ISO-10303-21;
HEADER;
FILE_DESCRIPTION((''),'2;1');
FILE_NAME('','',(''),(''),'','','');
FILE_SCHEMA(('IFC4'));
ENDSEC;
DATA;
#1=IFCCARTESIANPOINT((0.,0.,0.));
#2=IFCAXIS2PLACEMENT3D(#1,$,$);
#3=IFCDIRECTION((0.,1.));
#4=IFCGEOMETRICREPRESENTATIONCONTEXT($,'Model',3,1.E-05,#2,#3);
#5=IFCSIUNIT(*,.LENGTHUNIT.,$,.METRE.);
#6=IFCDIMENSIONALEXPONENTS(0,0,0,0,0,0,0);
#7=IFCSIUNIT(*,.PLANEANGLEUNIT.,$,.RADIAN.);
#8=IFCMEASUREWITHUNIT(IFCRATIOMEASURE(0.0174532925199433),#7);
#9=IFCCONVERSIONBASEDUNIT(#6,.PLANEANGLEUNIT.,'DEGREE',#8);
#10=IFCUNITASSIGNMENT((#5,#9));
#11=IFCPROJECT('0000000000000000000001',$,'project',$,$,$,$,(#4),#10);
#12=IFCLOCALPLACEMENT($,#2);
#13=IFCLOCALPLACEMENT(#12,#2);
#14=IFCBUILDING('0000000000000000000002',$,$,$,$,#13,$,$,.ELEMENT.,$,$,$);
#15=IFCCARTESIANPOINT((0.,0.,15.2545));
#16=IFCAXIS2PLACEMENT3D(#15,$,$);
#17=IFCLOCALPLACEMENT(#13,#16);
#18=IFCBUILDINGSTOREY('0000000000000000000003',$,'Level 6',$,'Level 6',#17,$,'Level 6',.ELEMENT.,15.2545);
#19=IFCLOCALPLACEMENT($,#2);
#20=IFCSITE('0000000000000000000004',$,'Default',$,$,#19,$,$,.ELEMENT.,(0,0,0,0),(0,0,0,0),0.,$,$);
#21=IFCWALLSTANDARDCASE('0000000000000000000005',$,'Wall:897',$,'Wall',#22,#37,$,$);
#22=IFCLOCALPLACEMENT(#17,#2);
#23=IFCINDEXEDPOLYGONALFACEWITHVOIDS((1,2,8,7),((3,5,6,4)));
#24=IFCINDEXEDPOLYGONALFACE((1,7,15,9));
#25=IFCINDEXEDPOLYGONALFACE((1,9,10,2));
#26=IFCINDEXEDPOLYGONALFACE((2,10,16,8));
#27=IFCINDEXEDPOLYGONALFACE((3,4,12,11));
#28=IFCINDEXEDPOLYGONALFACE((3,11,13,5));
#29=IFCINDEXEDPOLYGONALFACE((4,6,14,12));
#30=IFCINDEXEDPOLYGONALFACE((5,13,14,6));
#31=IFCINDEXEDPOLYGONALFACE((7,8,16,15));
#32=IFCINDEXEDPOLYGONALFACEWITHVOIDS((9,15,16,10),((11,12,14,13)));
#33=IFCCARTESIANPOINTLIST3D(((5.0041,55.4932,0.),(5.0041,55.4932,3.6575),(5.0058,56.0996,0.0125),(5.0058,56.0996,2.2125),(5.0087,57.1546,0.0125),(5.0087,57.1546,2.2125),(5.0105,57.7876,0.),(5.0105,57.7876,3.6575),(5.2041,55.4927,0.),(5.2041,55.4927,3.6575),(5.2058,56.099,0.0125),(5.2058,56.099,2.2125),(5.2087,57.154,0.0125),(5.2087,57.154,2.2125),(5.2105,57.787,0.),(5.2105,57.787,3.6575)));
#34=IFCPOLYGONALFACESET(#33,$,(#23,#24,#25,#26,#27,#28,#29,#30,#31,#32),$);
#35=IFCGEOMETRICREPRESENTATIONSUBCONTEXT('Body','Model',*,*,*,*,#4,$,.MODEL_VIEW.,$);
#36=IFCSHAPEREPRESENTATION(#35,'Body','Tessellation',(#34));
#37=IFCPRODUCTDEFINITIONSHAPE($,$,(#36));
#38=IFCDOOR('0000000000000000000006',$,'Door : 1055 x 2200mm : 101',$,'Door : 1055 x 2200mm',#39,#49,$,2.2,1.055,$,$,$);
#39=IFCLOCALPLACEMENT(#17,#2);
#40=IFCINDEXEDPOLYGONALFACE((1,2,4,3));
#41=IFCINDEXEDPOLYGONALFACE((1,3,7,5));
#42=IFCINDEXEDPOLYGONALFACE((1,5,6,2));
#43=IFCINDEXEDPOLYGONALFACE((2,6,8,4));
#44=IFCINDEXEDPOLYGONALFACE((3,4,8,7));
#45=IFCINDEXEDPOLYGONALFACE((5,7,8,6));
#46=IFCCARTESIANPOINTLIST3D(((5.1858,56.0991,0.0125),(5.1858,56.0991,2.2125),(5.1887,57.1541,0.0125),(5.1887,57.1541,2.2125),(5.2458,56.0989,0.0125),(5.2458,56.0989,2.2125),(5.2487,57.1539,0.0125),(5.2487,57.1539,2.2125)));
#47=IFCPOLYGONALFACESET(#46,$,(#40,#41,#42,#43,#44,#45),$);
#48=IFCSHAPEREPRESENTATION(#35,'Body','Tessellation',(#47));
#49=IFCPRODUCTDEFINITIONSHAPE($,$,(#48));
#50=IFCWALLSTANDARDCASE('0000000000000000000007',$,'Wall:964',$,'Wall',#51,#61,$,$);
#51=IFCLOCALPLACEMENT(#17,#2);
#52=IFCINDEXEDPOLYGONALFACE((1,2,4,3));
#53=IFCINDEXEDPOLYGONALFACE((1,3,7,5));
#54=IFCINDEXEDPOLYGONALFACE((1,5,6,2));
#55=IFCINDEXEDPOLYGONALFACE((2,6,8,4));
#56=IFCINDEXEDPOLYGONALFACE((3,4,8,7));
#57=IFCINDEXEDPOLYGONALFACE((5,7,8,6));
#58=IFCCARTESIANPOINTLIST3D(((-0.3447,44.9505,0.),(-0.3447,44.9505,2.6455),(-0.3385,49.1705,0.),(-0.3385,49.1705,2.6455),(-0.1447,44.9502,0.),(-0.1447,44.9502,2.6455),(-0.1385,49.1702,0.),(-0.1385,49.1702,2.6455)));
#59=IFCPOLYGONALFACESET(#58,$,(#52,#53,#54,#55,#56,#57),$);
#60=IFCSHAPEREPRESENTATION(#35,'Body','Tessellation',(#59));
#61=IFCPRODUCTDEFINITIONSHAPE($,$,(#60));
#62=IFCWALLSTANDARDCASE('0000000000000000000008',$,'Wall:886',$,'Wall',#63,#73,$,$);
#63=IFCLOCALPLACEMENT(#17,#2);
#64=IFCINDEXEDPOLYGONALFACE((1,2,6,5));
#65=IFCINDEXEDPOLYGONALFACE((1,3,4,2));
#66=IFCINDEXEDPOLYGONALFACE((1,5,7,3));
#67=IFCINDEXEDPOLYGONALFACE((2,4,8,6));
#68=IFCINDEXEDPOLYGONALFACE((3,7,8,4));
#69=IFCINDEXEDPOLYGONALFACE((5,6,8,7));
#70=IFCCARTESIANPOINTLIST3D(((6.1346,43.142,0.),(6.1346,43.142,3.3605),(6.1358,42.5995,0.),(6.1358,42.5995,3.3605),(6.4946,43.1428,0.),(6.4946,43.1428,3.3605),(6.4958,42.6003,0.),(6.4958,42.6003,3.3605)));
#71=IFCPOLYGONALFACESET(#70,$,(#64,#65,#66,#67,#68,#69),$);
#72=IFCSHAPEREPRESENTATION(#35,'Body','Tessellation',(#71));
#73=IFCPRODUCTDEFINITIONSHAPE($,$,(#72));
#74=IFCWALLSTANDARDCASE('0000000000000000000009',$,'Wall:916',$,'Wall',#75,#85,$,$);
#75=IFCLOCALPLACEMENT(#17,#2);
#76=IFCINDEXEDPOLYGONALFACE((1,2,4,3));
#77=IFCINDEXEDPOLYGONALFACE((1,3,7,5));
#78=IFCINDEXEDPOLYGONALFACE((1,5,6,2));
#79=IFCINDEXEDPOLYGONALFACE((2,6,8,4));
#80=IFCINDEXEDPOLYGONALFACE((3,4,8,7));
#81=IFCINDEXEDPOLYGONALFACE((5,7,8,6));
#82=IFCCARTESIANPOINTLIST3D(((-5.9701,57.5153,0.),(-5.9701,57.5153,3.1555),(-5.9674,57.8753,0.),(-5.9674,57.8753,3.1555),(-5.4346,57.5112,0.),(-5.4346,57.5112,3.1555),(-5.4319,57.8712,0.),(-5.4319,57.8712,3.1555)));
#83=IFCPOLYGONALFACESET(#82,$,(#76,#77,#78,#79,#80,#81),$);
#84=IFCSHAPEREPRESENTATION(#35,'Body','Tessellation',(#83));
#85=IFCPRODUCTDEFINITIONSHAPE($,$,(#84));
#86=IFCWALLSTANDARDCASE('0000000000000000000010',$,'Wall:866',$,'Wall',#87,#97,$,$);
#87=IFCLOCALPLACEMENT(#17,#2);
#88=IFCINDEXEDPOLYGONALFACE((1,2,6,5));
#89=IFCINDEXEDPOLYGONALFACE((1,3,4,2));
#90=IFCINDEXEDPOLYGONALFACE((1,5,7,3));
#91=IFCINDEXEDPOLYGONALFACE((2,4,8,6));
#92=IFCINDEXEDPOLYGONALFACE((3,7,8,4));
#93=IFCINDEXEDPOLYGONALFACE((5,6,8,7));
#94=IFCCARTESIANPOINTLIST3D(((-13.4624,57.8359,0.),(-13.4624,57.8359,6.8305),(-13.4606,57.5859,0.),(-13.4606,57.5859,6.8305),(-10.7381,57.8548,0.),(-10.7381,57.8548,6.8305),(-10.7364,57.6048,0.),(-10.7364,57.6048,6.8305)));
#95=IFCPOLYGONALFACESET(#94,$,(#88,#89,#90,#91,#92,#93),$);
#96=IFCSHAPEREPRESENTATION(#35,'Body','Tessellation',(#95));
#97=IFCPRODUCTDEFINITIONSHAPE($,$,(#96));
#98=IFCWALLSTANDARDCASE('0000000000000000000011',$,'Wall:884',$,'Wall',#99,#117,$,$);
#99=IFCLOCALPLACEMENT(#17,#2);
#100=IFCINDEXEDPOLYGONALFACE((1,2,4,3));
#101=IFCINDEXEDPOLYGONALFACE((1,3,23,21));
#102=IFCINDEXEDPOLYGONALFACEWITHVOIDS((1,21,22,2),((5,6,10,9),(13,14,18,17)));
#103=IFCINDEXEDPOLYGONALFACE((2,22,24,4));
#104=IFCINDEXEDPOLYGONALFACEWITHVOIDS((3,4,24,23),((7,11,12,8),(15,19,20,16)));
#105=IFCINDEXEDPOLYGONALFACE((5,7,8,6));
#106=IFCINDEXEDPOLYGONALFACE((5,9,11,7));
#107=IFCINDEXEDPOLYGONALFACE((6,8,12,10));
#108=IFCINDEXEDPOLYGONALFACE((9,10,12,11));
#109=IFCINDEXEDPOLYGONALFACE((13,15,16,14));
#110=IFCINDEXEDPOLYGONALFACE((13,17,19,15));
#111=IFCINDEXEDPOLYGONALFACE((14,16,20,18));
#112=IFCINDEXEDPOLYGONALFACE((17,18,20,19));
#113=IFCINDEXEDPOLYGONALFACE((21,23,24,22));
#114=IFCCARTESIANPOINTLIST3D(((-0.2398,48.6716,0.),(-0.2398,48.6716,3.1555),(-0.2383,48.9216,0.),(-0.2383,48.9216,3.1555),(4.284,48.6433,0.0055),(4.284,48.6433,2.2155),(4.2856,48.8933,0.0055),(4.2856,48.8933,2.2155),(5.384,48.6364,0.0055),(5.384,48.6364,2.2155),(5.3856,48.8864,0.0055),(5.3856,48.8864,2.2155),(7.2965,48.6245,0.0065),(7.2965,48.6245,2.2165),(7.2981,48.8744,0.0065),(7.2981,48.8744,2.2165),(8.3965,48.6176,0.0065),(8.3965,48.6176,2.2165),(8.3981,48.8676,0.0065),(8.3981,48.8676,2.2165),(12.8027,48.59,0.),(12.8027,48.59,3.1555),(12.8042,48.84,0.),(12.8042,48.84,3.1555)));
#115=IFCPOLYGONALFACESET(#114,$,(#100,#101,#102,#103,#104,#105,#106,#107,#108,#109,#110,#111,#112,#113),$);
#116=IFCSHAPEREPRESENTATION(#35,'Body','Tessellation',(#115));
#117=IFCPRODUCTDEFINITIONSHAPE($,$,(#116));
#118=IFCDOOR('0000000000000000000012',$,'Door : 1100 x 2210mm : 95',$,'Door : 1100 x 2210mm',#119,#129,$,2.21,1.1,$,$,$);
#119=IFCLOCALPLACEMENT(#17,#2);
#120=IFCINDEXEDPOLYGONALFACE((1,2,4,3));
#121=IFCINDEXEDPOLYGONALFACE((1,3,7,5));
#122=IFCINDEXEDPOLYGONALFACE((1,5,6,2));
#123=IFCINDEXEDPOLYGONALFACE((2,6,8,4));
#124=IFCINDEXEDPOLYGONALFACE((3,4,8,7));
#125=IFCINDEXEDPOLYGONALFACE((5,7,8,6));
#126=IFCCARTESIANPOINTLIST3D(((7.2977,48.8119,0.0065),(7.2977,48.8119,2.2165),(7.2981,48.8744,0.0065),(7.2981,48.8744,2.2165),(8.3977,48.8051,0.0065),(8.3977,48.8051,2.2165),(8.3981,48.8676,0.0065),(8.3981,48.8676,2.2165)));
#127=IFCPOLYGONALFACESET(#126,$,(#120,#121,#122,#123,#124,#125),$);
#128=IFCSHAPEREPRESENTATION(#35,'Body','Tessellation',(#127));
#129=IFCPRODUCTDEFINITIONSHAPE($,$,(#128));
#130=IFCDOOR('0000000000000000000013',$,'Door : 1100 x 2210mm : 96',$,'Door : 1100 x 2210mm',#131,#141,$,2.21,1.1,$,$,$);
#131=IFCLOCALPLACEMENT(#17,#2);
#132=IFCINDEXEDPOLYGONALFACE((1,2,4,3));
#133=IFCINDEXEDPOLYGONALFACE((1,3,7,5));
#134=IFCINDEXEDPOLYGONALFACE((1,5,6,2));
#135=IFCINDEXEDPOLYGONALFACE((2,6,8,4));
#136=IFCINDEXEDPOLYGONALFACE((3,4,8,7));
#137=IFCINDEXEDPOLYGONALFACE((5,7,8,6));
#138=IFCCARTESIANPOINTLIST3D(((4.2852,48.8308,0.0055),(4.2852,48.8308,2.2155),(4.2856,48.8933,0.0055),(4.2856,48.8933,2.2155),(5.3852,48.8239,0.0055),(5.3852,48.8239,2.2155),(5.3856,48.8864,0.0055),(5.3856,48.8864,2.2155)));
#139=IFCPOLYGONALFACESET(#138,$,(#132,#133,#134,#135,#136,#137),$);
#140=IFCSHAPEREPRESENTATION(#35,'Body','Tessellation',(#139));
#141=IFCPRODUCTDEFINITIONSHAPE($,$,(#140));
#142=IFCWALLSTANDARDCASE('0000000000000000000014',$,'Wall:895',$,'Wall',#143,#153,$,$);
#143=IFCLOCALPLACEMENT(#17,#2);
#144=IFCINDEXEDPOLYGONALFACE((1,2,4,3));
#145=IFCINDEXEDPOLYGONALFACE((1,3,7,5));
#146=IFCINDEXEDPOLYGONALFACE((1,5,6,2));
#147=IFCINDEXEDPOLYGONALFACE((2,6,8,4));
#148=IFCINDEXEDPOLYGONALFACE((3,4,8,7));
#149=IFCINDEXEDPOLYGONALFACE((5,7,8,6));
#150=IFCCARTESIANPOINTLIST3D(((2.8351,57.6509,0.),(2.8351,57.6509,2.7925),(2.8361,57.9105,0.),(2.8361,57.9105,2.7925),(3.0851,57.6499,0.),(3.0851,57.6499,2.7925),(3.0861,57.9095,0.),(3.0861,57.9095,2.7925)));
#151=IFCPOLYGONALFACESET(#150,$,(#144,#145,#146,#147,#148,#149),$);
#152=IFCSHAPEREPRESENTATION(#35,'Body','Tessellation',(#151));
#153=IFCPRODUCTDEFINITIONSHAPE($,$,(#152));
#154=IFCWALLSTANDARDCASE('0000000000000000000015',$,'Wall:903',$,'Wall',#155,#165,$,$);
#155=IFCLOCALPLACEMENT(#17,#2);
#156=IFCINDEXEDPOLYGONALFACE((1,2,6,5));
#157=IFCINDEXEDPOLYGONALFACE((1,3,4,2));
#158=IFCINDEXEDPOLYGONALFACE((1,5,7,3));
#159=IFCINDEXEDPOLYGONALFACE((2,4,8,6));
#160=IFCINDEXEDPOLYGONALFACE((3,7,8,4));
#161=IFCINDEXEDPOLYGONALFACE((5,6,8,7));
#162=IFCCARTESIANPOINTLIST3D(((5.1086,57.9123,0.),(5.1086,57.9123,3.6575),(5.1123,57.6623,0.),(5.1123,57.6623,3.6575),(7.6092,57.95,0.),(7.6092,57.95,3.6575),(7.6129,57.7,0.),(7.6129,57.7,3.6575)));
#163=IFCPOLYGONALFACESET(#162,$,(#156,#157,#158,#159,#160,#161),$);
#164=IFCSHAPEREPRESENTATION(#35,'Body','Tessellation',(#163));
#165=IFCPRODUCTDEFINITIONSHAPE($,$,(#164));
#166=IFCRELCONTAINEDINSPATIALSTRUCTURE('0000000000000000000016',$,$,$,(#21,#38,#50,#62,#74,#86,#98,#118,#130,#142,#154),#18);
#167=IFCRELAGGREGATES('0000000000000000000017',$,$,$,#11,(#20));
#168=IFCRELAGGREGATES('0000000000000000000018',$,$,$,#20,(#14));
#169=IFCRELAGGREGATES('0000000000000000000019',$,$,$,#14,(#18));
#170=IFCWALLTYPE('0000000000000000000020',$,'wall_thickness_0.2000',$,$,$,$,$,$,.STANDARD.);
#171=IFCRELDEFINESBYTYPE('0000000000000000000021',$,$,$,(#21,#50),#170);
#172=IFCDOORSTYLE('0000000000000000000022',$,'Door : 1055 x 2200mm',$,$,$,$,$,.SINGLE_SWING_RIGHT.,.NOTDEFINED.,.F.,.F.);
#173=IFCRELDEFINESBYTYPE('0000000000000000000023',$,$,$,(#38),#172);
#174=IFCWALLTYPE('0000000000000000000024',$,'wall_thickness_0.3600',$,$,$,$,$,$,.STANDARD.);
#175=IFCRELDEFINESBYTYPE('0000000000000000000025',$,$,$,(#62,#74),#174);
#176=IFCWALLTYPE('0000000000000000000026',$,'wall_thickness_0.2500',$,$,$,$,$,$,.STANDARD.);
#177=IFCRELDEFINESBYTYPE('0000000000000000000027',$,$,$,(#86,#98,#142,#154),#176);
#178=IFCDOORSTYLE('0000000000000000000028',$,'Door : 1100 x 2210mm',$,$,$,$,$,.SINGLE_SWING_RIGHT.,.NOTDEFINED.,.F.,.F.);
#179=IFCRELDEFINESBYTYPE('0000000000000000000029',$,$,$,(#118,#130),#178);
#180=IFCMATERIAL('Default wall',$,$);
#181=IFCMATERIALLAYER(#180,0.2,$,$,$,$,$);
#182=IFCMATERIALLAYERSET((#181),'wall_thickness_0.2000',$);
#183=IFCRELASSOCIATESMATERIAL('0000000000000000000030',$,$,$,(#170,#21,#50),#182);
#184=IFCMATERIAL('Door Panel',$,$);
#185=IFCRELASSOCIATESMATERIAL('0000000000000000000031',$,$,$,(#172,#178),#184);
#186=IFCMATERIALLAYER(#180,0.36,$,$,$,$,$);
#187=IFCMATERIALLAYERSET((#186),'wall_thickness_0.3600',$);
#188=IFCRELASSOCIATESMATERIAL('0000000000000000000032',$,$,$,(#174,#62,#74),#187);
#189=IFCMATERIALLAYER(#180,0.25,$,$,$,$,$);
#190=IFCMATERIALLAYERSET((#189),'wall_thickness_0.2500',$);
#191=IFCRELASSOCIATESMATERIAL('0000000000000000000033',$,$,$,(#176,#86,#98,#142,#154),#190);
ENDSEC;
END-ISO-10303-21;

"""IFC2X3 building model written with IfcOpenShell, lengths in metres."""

from ifc_helpers import new_model, entity, si_unit, converted_unit, direction, frame, frame_2d, origin, origin_2d_with_axis, place, context, subcontext, project, spatial, polyline, rectangle, outline, extrude, source, transform, mapped, material, layer, layer_set, layer_usage, type_object, type_shapes, element, fill, save


model = new_model("IFC2X3")

# Units and contexts
model_context = context("Model", 3, precision=1e-05, world=origin(), true_north=direction((0.0, 1.0)))
body_context = subcontext(model_context, "Body", "Model", "MODEL_VIEW")
ifc_project = project(units=[si_unit("LENGTHUNIT", "METRE"), converted_unit("PLANEANGLEUNIT", "DEGREE", entity("IfcRatioMeasure", 0.0174532925199433), si_unit("PLANEANGLEUNIT", "RADIAN"), dimensions=[0, 0, 0, 0, 0, 0, 0])], contexts=[model_context])

# Site, building, storey
site_placement = place(None, origin())
site = spatial("IfcSite", under=ifc_project, at=site_placement, Name="Default", CompositionType="ELEMENT", RefLatitude=(0, 0, 0, 0), RefLongitude=(0, 0, 0, 0), RefElevation=0.0)
placement = place(None, origin())
building_placement = place(placement, origin())
building = spatial("IfcBuilding", under=site, at=building_placement, CompositionType="ELEMENT")
storey_placement = place(building_placement, frame((0.0, 0.0, 15.2545)))
storey = spatial("IfcBuildingStorey", under=building, at=storey_placement, Name="Level 6", ObjectType="Level 6", LongName="Level 6", CompositionType="ELEMENT", Elevation=15.2545)

# Wall, opening, door
ifc_material_1 = material(Name="Default wall")
ifc_layer_1 = layer(ifc_material_1, 0.2)
ifc_layer_set_1 = layer_set([ifc_layer_1], Name="wall_thickness_0.2000")
ifc_layer_usage_1 = layer_usage(ifc_layer_set_1, "AXIS2", "POSITIVE", -0.1)
wall_type_1 = type_object("IfcWallType", Name="wall_thickness_0.2000", PredefinedType="STANDARD", material=ifc_layer_set_1)
wall_1_placement = place(storey_placement, frame((5.1105, 57.7873, 0.0), z_axis=(0.0, 0.0, 1.0), x_axis=(-0.00277, -0.999996, 0.0)))
wall_1 = element("IfcWallStandardCase", 1, at=wall_1_placement, inside=storey, type_object=wall_type_1, material=ifc_layer_usage_1, Name="Wall:897", ObjectType="Wall", context=body_context, shape_type="SweptSolid", body=[
    extrude(outline(polyline([(2.2944, -0.1), (2.2944, 0.1), (0.0, 0.1), (0.0, -0.1), (2.2944, -0.1)])), origin(), (0.0, 0.0, 1.0), 3.6575),
])
opening_1_placement = place(wall_1_placement, frame((0.633, -0.1, 0.0125)))
opening_1 = element("IfcOpeningElement", 2, at=opening_1_placement, cuts=wall_1, ObjectType="Opening", context=body_context, shape_type="SweptSolid", body=[
    extrude(rectangle(XDim=1.055, YDim=2.2, at=frame_2d((1.1, 0.5275), x_axis=(0.0, 1.0))), frame((0.0, 0.0, 0.0), z_axis=(0.0, 1.0, 0.0), x_axis=(0.0, 0.0, 1.0)), (0.0, 0.0, 1.0), 0.2),
])
ifc_material_2 = material(Name="Door Panel")
door_style_1 = type_object("IfcDoorStyle", Name="Door : 1055 x 2200mm", ConstructionType="NOTDEFINED", OperationType="SINGLE_SWING_RIGHT", ParameterTakesPrecedence=False, Sizeable=False, material=ifc_material_2)
shared_shape_1 = source(origin(), body_context, "Body", "SweptSolid", [
    extrude(rectangle(XDim=0.06, YDim=1.055, at=origin_2d_with_axis()), frame((0.5275, 0.21, 0.0), z_axis=(0.0, 0.0, 1.0), x_axis=(0.0, 1.0, 0.0)), (0.0, 0.0, 1.0), 2.2),
])
type_shapes(door_style_1, [shared_shape_1])
door_1_placement = place(opening_1_placement, origin())
door_1 = element("IfcDoor", 3, at=door_1_placement, inside=storey, type_object=door_style_1, Name="Door : 1055 x 2200mm : 101", ObjectType="Door : 1055 x 2200mm", OverallHeight=2.2, OverallWidth=1.055, context=body_context, shape_type="MappedRepresentation", body=[
    mapped(shared_shape_1, transform((0.0, 0.0, 0.0), scale=1.0)),
])
fill(opening_1, door_1)

# Walls
wall_2_placement = place(storey_placement, frame((-0.2385, 49.1704, 0.0), z_axis=(0.0, 0.0, 1.0), x_axis=(-0.001466, -0.999999, 0.0)))
element("IfcWallStandardCase", 4, at=wall_2_placement, inside=storey, type_object=wall_type_1, material=ifc_layer_usage_1, Name="Wall:964", ObjectType="Wall", context=body_context, shape_type="SweptSolid", body=[
    extrude(outline(polyline([(4.22, -0.1), (4.22, 0.1), (0.0, 0.1), (0.0, -0.1), (4.22, -0.1)])), origin(), (0.0, 0.0, 1.0), 2.6455),
])
ifc_layer_2 = layer(ifc_material_1, 0.36)
ifc_layer_set_2 = layer_set([ifc_layer_2], Name="wall_thickness_0.3600")
ifc_layer_usage_2 = layer_usage(ifc_layer_set_2, "AXIS2", "POSITIVE", -0.18)
wall_type_2 = type_object("IfcWallType", Name="wall_thickness_0.3600", PredefinedType="STANDARD", material=ifc_layer_set_2)
wall_3_placement = place(storey_placement, frame((6.3146, 43.1424, 0.0), z_axis=(0.0, 0.0, 1.0), x_axis=(0.002296, -0.999997, 0.0)))
element("IfcWallStandardCase", 5, at=wall_3_placement, inside=storey, type_object=wall_type_2, material=ifc_layer_usage_2, Name="Wall:886", ObjectType="Wall", context=body_context, shape_type="SweptSolid", body=[
    extrude(outline(polyline([(0.5425, -0.18), (0.5425, 0.18), (0.0, 0.18), (0.0, -0.18), (0.5425, -0.18)])), origin(), (0.0, 0.0, 1.0), 3.3605),
])
wall_4_placement = place(storey_placement, frame((-5.4333, 57.6912, 0.0), z_axis=(0.0, 0.0, 1.0), x_axis=(-0.999972, 0.007529, 0.0)))
element("IfcWallStandardCase", 6, at=wall_4_placement, inside=storey, type_object=wall_type_2, material=ifc_layer_usage_2, Name="Wall:916", ObjectType="Wall", context=body_context, shape_type="SweptSolid", body=[
    extrude(outline(polyline([(0.5355, -0.18), (0.5355, 0.18), (0.0, 0.18), (0.0, -0.18), (0.5355, -0.18)])), origin(), (0.0, 0.0, 1.0), 3.1555),
])
ifc_layer_3 = layer(ifc_material_1, 0.25)
ifc_layer_set_3 = layer_set([ifc_layer_3], Name="wall_thickness_0.2500")
ifc_layer_usage_3 = layer_usage(ifc_layer_set_3, "AXIS2", "POSITIVE", -0.125)
wall_type_3 = type_object("IfcWallType", Name="wall_thickness_0.2500", PredefinedType="STANDARD", material=ifc_layer_set_3)
wall_5_placement = place(storey_placement, frame((-13.4615, 57.7109, 0.0), z_axis=(0.0, 0.0, 1.0), x_axis=(0.999976, 0.006935, 0.0)))
element("IfcWallStandardCase", 7, at=wall_5_placement, inside=storey, type_object=wall_type_3, material=ifc_layer_usage_3, Name="Wall:866", ObjectType="Wall", context=body_context, shape_type="SweptSolid", body=[
    extrude(outline(polyline([(2.7243, -0.125), (2.7243, 0.125), (0.0, 0.125), (0.0, -0.125), (2.7243, -0.125)])), origin(), (0.0, 0.0, 1.0), 6.8305),
])

# Wall, openings, doors
wall_6_placement = place(storey_placement, frame((-0.2391, 48.7966, 0.0), z_axis=(0.0, 0.0, 1.0), x_axis=(0.99998, -0.006257, 0.0)))
wall_6 = element("IfcWallStandardCase", 8, at=wall_6_placement, inside=storey, type_object=wall_type_3, material=ifc_layer_usage_3, Name="Wall:884", ObjectType="Wall", context=body_context, shape_type="SweptSolid", body=[
    extrude(outline(polyline([(13.0428, -0.125), (13.0428, 0.125), (0.0, 0.125), (0.0, -0.125), (13.0428, -0.125)])), origin(), (0.0, 0.0, 1.0), 3.1555),
])
opening_2_placement = place(wall_6_placement, frame((7.5365, -0.125, 0.0065)))
opening_2 = element("IfcOpeningElement", 9, at=opening_2_placement, cuts=wall_6, ObjectType="Opening", context=body_context, shape_type="SweptSolid", body=[
    extrude(rectangle(XDim=1.1, YDim=2.21, at=frame_2d((1.105, 0.55), x_axis=(0.0, 1.0))), frame((0.0, 0.0, 0.0), z_axis=(0.0, 1.0, 0.0), x_axis=(0.0, 0.0, 1.0)), (0.0, 0.0, 1.0), 0.25),
])
opening_3_placement = place(wall_6_placement, frame((4.5239, -0.125, 0.0055)))
opening_3 = element("IfcOpeningElement", 10, at=opening_3_placement, cuts=wall_6, ObjectType="Opening", context=body_context, shape_type="SweptSolid", body=[
    extrude(rectangle(XDim=1.1, YDim=2.21, at=frame_2d((1.105, 0.55), x_axis=(0.0, 1.0))), frame((0.0, 0.0, 0.0), z_axis=(0.0, 1.0, 0.0), x_axis=(0.0, 0.0, 1.0)), (0.0, 0.0, 1.0), 0.25),
])
door_style_2 = type_object("IfcDoorStyle", Name="Door : 1100 x 2210mm", ConstructionType="NOTDEFINED", OperationType="SINGLE_SWING_RIGHT", ParameterTakesPrecedence=False, Sizeable=False, material=ifc_material_2)
shared_shape_2 = source(origin(), body_context, "Body", "SweptSolid", [
    extrude(rectangle(XDim=0.0625, YDim=1.1, at=origin_2d_with_axis()), frame((0.55, 0.2188, 0.0), z_axis=(0.0, 0.0, 1.0), x_axis=(0.0, 1.0, 0.0)), (0.0, 0.0, 1.0), 2.21),
])
type_shapes(door_style_2, [shared_shape_2])
door_2_placement = place(opening_2_placement, origin())
door_2 = element("IfcDoor", 11, at=door_2_placement, inside=storey, type_object=door_style_2, Name="Door : 1100 x 2210mm : 95", ObjectType="Door : 1100 x 2210mm", OverallHeight=2.21, OverallWidth=1.1, context=body_context, shape_type="MappedRepresentation", body=[
    mapped(shared_shape_2, transform((0.0, 0.0, 0.0), scale=1.0)),
])
fill(opening_2, door_2)
door_3_placement = place(opening_3_placement, origin())
door_3 = element("IfcDoor", 12, at=door_3_placement, inside=storey, type_object=door_style_2, Name="Door : 1100 x 2210mm : 96", ObjectType="Door : 1100 x 2210mm", OverallHeight=2.21, OverallWidth=1.1, context=body_context, shape_type="MappedRepresentation", body=[
    mapped(shared_shape_2, transform((0.0, 0.0, 0.0), scale=1.0)),
])
fill(opening_3, door_3)

# Walls
wall_7_placement = place(storey_placement, frame((2.9611, 57.91, 0.0), z_axis=(0.0, 0.0, 1.0), x_axis=(-0.003849, -0.999993, 0.0)))
element("IfcWallStandardCase", 13, at=wall_7_placement, inside=storey, type_object=wall_type_3, material=ifc_layer_usage_3, Name="Wall:895", ObjectType="Wall", context=body_context, shape_type="SweptSolid", body=[
    extrude(outline(polyline([(0.2596, -0.125), (0.2596, 0.125), (0.0, 0.125), (0.0, -0.125), (0.2596, -0.125)])), origin(), (0.0, 0.0, 1.0), 2.7925),
])
wall_8_placement = place(storey_placement, frame((5.1105, 57.7873, 0.0), z_axis=(0.0, 0.0, 1.0), x_axis=(0.999886, 0.015078, 0.0)))
element("IfcWallStandardCase", 14, at=wall_8_placement, inside=storey, type_object=wall_type_3, material=ifc_layer_usage_3, Name="Wall:903", ObjectType="Wall", context=body_context, shape_type="SweptSolid", body=[
    extrude(outline(polyline([(2.5009, -0.125), (2.5009, 0.125), (0.0, 0.125), (0.0, -0.125), (2.5009, -0.125)])), origin(), (0.0, 0.0, 1.0), 3.6575),
])

save(model, "model.ifc")
